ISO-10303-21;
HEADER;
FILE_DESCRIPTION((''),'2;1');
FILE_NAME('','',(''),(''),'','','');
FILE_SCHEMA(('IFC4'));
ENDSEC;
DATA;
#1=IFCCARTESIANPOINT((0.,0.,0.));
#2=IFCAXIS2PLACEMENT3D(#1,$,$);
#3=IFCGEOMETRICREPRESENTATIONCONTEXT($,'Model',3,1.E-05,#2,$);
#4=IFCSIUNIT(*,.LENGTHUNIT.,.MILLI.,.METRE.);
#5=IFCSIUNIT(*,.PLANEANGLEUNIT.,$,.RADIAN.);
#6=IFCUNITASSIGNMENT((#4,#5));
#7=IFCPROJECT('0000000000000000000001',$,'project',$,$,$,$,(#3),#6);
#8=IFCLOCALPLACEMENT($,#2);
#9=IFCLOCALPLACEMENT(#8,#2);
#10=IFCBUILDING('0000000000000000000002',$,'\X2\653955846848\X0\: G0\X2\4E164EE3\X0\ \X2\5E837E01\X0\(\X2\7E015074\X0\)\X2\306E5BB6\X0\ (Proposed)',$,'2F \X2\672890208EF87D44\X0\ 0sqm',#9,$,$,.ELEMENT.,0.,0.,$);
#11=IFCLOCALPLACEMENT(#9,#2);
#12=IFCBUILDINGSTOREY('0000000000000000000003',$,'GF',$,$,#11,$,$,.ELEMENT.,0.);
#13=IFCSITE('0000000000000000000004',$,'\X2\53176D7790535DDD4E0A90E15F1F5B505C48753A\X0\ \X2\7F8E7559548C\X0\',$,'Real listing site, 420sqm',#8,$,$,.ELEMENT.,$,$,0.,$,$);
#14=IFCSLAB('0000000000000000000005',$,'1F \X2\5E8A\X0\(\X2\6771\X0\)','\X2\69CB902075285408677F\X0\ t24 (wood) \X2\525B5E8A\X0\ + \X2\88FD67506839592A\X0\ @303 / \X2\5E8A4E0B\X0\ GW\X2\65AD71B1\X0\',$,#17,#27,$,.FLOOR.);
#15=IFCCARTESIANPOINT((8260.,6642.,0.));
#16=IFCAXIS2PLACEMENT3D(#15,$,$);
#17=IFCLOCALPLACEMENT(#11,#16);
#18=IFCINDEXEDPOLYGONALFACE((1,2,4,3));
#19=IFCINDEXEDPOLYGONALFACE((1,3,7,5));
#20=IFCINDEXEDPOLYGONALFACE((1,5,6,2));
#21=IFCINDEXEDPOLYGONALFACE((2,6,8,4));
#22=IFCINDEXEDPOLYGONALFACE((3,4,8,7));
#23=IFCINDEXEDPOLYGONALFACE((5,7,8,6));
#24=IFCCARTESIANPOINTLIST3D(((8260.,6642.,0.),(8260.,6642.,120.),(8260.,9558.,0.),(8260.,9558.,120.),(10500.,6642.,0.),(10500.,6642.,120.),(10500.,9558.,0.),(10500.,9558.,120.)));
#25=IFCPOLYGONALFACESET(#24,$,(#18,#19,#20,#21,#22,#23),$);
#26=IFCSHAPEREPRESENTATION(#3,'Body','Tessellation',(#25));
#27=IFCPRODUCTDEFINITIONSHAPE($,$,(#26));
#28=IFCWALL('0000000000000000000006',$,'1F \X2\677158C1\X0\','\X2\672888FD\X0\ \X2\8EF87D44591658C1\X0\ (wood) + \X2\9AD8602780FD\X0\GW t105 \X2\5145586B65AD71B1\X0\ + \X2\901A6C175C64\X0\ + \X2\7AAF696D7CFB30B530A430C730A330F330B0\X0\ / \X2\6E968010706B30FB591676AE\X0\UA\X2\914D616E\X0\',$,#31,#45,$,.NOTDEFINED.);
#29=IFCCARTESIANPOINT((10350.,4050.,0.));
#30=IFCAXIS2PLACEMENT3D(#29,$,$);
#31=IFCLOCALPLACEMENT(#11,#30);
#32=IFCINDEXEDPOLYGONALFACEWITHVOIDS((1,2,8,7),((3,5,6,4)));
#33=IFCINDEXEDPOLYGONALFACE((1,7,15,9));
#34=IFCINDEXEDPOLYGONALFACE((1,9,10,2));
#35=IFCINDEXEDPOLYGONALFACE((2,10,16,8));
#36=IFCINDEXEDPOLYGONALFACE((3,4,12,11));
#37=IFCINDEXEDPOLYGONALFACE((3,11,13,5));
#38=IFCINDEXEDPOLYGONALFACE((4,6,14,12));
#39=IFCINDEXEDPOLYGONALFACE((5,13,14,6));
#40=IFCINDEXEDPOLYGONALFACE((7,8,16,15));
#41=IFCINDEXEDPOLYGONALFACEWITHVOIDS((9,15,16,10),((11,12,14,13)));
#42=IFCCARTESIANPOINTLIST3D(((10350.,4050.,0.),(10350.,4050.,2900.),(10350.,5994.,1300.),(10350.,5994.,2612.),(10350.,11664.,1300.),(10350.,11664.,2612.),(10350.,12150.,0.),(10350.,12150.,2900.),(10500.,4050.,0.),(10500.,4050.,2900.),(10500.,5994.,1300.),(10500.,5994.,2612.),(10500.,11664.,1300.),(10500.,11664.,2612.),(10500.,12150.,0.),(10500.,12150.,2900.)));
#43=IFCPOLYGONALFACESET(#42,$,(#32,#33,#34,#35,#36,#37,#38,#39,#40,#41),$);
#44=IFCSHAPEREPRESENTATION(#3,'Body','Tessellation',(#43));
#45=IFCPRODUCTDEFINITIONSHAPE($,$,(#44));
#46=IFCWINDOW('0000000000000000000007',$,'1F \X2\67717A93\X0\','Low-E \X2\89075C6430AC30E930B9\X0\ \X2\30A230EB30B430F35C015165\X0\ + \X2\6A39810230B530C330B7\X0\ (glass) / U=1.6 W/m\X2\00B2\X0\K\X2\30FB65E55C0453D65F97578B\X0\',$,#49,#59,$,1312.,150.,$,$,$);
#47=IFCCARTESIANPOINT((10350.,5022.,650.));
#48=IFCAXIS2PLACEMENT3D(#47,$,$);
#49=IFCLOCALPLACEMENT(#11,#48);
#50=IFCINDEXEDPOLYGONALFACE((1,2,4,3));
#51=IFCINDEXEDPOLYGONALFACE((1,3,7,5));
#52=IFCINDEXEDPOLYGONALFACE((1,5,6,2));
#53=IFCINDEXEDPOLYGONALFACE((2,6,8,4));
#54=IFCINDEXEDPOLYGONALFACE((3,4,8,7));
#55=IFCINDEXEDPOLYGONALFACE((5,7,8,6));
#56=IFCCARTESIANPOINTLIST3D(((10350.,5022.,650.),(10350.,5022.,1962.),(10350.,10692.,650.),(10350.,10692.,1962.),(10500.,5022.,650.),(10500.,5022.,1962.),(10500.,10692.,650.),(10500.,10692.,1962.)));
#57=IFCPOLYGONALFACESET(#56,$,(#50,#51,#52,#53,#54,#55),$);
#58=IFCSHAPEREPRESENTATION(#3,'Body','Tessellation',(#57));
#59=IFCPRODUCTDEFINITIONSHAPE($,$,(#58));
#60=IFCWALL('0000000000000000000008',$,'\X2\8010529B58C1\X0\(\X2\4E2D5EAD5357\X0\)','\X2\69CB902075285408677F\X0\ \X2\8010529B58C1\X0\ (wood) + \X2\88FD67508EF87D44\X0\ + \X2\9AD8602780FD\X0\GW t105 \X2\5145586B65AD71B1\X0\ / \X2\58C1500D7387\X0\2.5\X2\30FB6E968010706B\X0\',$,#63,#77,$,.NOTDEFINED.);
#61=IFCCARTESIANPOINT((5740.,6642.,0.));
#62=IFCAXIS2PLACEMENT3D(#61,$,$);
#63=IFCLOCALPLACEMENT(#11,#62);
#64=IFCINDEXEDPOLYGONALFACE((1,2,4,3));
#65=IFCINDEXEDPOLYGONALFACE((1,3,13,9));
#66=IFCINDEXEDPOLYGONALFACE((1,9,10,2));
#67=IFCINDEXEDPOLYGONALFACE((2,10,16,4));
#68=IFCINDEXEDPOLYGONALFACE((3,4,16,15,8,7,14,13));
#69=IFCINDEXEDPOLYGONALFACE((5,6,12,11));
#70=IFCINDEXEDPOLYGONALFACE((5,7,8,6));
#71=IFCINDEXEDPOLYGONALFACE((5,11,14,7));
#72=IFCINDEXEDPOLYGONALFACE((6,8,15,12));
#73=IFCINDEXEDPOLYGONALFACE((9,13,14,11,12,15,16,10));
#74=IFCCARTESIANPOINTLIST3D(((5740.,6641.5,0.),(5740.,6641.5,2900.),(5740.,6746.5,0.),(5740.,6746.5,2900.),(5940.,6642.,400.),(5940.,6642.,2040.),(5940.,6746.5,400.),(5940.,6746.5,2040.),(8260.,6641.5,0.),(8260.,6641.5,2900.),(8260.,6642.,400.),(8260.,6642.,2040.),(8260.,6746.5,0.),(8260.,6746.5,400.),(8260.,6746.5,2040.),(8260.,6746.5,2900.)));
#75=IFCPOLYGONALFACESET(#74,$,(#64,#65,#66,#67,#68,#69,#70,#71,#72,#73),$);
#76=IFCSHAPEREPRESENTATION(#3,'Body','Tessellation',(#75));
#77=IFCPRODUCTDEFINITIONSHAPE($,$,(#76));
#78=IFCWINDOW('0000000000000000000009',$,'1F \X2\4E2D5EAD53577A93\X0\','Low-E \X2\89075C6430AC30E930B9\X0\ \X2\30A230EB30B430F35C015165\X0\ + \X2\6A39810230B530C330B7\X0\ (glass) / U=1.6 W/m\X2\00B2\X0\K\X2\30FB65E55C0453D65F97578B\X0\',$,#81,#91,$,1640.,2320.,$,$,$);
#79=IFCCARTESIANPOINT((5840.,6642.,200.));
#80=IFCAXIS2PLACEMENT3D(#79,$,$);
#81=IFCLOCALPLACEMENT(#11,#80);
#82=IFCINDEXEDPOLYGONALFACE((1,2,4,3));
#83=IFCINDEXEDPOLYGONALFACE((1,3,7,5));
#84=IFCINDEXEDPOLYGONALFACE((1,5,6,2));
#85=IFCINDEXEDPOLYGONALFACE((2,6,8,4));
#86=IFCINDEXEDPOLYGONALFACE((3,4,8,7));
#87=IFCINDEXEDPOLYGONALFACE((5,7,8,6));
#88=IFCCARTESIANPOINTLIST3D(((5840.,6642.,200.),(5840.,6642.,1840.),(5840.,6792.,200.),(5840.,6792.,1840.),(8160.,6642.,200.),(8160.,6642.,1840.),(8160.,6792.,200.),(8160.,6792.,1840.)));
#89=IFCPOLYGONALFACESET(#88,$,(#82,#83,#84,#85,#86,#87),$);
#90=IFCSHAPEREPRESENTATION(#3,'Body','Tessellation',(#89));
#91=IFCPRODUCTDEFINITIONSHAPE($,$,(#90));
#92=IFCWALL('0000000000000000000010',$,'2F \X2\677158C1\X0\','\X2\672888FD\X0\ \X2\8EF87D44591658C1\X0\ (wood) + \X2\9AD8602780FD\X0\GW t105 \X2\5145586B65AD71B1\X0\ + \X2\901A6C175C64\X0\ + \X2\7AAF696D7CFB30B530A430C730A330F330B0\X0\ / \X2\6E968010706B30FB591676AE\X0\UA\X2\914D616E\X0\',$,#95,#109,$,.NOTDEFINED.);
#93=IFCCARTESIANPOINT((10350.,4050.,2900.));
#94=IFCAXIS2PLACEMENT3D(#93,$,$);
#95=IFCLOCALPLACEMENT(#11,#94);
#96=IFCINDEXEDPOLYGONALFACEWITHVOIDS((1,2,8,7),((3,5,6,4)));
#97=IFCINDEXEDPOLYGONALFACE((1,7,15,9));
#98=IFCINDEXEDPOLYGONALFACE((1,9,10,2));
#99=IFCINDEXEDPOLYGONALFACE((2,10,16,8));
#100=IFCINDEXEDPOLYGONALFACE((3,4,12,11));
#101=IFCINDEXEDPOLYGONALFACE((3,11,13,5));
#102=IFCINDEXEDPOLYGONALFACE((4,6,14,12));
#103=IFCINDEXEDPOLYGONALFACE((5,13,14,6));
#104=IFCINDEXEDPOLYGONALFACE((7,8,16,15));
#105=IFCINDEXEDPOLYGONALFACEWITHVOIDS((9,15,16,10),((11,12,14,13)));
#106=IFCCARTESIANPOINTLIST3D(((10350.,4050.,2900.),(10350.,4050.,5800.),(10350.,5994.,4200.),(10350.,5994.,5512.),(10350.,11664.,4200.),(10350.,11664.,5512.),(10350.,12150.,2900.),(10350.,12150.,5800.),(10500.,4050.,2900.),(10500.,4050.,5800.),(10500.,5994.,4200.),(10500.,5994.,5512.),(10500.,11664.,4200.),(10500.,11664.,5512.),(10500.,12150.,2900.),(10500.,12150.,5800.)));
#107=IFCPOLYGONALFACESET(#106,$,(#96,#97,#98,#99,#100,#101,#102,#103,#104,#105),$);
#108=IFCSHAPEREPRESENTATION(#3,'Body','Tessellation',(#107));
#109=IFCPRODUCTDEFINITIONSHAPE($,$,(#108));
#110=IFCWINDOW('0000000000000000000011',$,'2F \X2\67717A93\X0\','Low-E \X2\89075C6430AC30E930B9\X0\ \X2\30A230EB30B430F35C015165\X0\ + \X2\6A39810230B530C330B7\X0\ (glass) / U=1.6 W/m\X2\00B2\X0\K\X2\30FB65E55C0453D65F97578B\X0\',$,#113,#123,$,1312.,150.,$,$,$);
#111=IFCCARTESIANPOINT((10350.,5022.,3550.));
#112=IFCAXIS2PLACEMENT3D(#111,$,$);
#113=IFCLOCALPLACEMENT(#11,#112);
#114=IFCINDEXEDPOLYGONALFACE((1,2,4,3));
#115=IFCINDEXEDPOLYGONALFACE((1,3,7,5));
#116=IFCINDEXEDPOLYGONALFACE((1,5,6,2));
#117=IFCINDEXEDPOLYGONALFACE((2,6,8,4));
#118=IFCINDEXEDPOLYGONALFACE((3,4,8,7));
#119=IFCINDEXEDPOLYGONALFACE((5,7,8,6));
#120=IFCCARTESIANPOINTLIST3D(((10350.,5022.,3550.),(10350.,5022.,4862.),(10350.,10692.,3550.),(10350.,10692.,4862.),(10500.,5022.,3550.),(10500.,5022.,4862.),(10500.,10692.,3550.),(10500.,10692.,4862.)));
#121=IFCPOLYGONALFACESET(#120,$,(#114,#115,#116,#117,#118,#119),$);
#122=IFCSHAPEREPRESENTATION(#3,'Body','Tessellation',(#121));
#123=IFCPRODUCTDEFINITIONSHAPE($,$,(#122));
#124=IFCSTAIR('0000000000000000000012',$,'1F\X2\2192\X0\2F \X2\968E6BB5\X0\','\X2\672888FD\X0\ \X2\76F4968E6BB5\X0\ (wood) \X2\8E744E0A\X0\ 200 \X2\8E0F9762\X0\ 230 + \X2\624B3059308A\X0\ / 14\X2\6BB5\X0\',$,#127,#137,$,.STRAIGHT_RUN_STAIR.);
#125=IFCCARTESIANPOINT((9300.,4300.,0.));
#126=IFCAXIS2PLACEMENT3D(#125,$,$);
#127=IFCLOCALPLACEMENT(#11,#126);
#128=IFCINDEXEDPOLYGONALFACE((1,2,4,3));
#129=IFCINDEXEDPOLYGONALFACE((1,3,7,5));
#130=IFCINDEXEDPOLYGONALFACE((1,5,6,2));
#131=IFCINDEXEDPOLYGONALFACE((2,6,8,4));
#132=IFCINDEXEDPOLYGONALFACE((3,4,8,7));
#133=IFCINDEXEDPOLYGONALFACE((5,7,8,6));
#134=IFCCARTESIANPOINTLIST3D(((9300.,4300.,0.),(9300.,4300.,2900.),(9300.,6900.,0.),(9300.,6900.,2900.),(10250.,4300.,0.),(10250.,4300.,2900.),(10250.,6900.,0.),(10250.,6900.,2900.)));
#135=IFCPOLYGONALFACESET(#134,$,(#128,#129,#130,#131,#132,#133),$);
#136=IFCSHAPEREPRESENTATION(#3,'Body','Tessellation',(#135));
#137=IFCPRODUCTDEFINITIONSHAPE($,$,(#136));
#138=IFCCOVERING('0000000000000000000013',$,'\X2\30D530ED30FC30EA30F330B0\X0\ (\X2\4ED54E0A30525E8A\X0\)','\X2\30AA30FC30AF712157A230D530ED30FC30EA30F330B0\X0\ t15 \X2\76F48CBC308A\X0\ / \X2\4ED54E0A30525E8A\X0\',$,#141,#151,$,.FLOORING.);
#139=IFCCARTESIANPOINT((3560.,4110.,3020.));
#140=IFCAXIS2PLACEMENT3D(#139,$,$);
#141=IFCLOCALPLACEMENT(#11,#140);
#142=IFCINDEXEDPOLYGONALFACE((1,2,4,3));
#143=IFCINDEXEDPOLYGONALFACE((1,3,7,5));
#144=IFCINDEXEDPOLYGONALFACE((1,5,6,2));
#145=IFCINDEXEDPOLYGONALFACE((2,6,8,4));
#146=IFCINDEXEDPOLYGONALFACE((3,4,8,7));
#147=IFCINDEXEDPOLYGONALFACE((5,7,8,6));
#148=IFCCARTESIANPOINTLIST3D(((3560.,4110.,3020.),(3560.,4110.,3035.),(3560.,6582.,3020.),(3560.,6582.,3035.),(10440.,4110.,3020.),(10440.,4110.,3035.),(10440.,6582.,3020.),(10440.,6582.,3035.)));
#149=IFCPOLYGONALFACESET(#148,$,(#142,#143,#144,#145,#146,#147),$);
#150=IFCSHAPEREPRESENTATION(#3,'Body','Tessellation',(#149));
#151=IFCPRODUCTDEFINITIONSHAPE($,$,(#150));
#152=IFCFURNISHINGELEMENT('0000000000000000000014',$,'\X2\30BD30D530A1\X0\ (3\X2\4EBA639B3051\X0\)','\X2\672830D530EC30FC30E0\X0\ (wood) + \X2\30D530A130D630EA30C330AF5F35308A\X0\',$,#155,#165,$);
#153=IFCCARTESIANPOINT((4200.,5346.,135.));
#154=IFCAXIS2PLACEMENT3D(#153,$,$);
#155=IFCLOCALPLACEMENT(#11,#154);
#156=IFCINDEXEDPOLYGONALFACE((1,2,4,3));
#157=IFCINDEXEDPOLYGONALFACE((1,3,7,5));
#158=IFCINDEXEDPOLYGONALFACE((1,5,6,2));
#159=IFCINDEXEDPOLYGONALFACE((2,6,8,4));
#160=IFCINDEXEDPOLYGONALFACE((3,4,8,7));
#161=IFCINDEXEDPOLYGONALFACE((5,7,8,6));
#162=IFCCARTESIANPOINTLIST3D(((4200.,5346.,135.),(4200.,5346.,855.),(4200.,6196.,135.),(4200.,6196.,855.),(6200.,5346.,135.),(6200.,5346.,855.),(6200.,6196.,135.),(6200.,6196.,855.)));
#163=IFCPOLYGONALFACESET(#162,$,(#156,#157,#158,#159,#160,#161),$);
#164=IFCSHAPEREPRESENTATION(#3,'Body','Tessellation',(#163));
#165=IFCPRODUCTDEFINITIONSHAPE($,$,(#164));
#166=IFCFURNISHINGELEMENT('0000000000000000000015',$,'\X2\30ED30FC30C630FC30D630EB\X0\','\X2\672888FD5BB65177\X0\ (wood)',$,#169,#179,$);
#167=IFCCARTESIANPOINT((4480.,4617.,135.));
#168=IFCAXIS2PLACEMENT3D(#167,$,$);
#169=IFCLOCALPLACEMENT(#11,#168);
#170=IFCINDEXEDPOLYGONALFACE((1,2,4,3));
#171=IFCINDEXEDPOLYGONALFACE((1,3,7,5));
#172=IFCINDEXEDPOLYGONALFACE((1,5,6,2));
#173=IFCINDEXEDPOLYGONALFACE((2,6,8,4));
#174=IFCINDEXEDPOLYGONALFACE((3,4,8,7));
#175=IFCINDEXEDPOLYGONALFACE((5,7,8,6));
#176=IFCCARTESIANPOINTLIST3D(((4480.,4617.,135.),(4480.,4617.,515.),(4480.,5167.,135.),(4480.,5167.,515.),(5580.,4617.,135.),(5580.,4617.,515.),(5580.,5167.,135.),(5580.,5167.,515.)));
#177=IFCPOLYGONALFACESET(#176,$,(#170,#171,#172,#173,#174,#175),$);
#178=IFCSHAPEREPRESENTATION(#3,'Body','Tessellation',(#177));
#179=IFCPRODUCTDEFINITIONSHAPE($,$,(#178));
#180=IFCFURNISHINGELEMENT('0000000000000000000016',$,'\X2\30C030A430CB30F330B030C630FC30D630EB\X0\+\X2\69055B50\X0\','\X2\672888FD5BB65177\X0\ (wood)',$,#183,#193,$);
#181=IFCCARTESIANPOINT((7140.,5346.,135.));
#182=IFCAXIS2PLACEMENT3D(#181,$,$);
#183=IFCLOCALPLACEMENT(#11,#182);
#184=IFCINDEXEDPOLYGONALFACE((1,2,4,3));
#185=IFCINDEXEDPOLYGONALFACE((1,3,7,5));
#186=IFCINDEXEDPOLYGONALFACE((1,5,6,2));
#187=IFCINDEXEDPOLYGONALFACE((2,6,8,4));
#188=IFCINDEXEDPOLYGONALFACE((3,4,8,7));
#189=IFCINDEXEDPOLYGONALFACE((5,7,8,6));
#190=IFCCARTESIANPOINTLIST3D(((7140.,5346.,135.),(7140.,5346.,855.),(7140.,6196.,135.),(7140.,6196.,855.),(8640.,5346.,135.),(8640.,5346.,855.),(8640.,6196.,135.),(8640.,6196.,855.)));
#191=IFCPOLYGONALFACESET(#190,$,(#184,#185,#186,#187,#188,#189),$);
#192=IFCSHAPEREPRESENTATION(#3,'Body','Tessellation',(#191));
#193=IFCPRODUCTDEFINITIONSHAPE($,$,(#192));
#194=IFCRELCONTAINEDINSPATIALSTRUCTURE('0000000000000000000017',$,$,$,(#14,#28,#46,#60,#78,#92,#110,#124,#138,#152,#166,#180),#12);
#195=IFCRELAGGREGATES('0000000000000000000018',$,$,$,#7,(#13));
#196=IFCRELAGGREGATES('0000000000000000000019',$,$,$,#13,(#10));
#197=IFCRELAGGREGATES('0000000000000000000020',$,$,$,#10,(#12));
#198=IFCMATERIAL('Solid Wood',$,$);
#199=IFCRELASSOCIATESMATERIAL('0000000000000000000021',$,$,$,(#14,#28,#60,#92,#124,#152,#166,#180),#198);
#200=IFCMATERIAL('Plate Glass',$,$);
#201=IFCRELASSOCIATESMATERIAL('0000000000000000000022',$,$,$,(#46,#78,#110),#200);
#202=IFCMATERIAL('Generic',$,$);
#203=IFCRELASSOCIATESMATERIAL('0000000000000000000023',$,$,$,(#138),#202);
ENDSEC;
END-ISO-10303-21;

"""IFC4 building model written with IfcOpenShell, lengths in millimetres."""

from ifc_helpers import new_model, si_unit, frame, frame_2d, origin, place, context, project, spatial, rectangle, extrude, material, element, fill, save


model = new_model("IFC4")

# Units and contexts
model_context = context("Model", 3, precision=1e-05, world=origin())
ifc_project = project(units=[si_unit("LENGTHUNIT", "METRE", prefix="MILLI"), si_unit("PLANEANGLEUNIT", "RADIAN")], contexts=[model_context])

# Site, building, storey
site_placement = place(None, origin())
site = spatial("IfcSite", under=ifc_project, at=site_placement, Name="北海道川上郡弟子屈町 美留和", ObjectType="Real listing site, 420sqm", CompositionType="ELEMENT", RefElevation=0.0)
building_placement = place(site_placement, origin())
building = spatial("IfcBuilding", under=site, at=building_placement, Name="改善案: G0世代 広縁(縁側)の家 (Proposed)", ObjectType="2F 木造軸組 0sqm", CompositionType="ELEMENT", ElevationOfRefHeight=0.0, ElevationOfTerrain=0.0)
storey_placement = place(building_placement, origin())
storey = spatial("IfcBuildingStorey", under=building, at=storey_placement, Name="GF", CompositionType="ELEMENT", Elevation=0.0)

# Slab
ifc_material_1 = material(Name="Solid Wood")
slab_placement = place(storey_placement, frame((8260.0, 6642.0, 0.0)))
element("IfcSlab", 1, at=slab_placement, inside=storey, material=ifc_material_1, Name="1F 床(東)", Description="構造用合板 t24 (wood) 剛床 + 製材根太 @303 / 床下 GW断熱", PredefinedType="FLOOR", context=model_context, shape_type="SweptSolid", body=[
    extrude(rectangle(XDim=2240.0, YDim=2916.0, at=frame_2d((1120.0, 1458.0))), frame((8260.0, 6642.0, 0.0)), (0.0, 0.0, 1.0), 120.0),
])

# Walls, openings, windows
wall_1_placement = place(storey_placement, frame((10350.0, 4050.0, 0.0)))
wall_1 = element("IfcWall", 2, at=wall_1_placement, inside=storey, material=ifc_material_1, Name="1F 東壁", Description="木製 軸組外壁 (wood) + 高性能GW t105 充填断熱 + 通気層 + 窯業系サイディング / 準耐火・外皮UA配慮", PredefinedType="NOTDEFINED", context=model_context, shape_type="SweptSolid", body=[
    extrude(rectangle(XDim=150.0, YDim=8100.0, at=frame_2d((75.0, 4050.0))), frame((10350.0, 4050.0, 0.0)), (0.0, 0.0, 1.0), 2900.0),
])
opening_1_placement = place(storey_placement, frame((10350.0, 5022.0, 650.0)))
opening_1 = element("IfcOpeningElement", 3, at=opening_1_placement, cuts=wall_1, PredefinedType="NOTDEFINED", context=model_context, shape_type="SweptSolid", body=[
    extrude(rectangle(XDim=150.0, YDim=5670.0, at=frame_2d((75.0, 2835.0))), frame((10350.0, 5022.0, 650.0)), (0.0, 0.0, 1.0), 1312.0),
])
ifc_material_2 = material(Name="Plate Glass")
window_1_placement = place(storey_placement, frame((10350.0, 5022.0, 650.0)))
window_1 = element("IfcWindow", 4, at=window_1_placement, inside=storey, material=ifc_material_2, Name="1F 東窓", Description="Low-E 複層ガラス アルゴン封入 + 樹脂サッシ (glass) / U=1.6 W/m²K・日射取得型", OverallHeight=1312.0, OverallWidth=150.0, context=model_context, shape_type="SweptSolid", body=[
    extrude(rectangle(XDim=150.0, YDim=5670.0, at=frame_2d((75.0, 2835.0))), frame((10350.0, 5022.0, 650.0)), (0.0, 0.0, 1.0), 1312.0),
])
fill(opening_1, window_1)
wall_2_placement = place(storey_placement, frame((5740.0, 6642.0, 0.0)))
wall_2 = element("IfcWall", 5, at=wall_2_placement, inside=storey, material=ifc_material_1, Name="耐力壁(中庭南)", Description="構造用合板 耐力壁 (wood) + 製材軸組 + 高性能GW t105 充填断熱 / 壁倍率2.5・準耐火", PredefinedType="NOTDEFINED", context=model_context, shape_type="SweptSolid", body=[
    extrude(rectangle(XDim=2520.0, YDim=105.0, at=frame_2d((1260.0, 52.0))), frame((5740.0, 6642.0, 0.0)), (0.0, 0.0, 1.0), 2900.0),
])
opening_2_placement = place(storey_placement, frame((5840.0, 6642.0, 200.0)))
opening_2 = element("IfcOpeningElement", 6, at=opening_2_placement, cuts=wall_2, PredefinedType="NOTDEFINED", context=model_context, shape_type="SweptSolid", body=[
    extrude(rectangle(XDim=2320.0, YDim=150.0, at=frame_2d((1160.0, 75.0))), frame((5840.0, 6642.0, 200.0)), (0.0, 0.0, 1.0), 1640.0),
])
window_2_placement = place(storey_placement, frame((5840.0, 6642.0, 200.0)))
window_2 = element("IfcWindow", 7, at=window_2_placement, inside=storey, material=ifc_material_2, Name="1F 中庭南窓", Description="Low-E 複層ガラス アルゴン封入 + 樹脂サッシ (glass) / U=1.6 W/m²K・日射取得型", OverallHeight=1640.0, OverallWidth=2320.0, context=model_context, shape_type="SweptSolid", body=[
    extrude(rectangle(XDim=2320.0, YDim=150.0, at=frame_2d((1160.0, 75.0))), frame((5840.0, 6642.0, 200.0)), (0.0, 0.0, 1.0), 1640.0),
])
fill(opening_2, window_2)

# Wall, opening, window
wall_3_placement = place(storey_placement, frame((10350.0, 4050.0, 2900.0)))
wall_3 = element("IfcWall", 8, at=wall_3_placement, inside=storey, material=ifc_material_1, Name="2F 東壁", Description="木製 軸組外壁 (wood) + 高性能GW t105 充填断熱 + 通気層 + 窯業系サイディング / 準耐火・外皮UA配慮", PredefinedType="NOTDEFINED", context=model_context, shape_type="SweptSolid", body=[
    extrude(rectangle(XDim=150.0, YDim=8100.0, at=frame_2d((75.0, 4050.0))), frame((10350.0, 4050.0, 2900.0)), (0.0, 0.0, 1.0), 2900.0),
])
opening_3_placement = place(storey_placement, frame((10350.0, 5022.0, 3550.0)))
opening_3 = element("IfcOpeningElement", 9, at=opening_3_placement, cuts=wall_3, PredefinedType="NOTDEFINED", context=model_context, shape_type="SweptSolid", body=[
    extrude(rectangle(XDim=150.0, YDim=5670.0, at=frame_2d((75.0, 2835.0))), frame((10350.0, 5022.0, 3550.0)), (0.0, 0.0, 1.0), 1312.0),
])
window_3_placement = place(storey_placement, frame((10350.0, 5022.0, 3550.0)))
window_3 = element("IfcWindow", 10, at=window_3_placement, inside=storey, material=ifc_material_2, Name="2F 東窓", Description="Low-E 複層ガラス アルゴン封入 + 樹脂サッシ (glass) / U=1.6 W/m²K・日射取得型", OverallHeight=1312.0, OverallWidth=150.0, context=model_context, shape_type="SweptSolid", body=[
    extrude(rectangle(XDim=150.0, YDim=5670.0, at=frame_2d((75.0, 2835.0))), frame((10350.0, 5022.0, 3550.0)), (0.0, 0.0, 1.0), 1312.0),
])
fill(opening_3, window_3)

# Stair
stair_placement = place(storey_placement, frame((9300.0, 4300.0, 0.0)))
element("IfcStair", 11, at=stair_placement, inside=storey, material=ifc_material_1, Name="1F→2F 階段", Description="木製 直階段 (wood) 蹴上 200 踏面 230 + 手すり / 14段", PredefinedType="STRAIGHT_RUN_STAIR", context=model_context, shape_type="SweptSolid", body=[
    extrude(rectangle(XDim=950.0, YDim=2600.0, at=frame_2d((475.0, 1300.0))), frame((9300.0, 4300.0, 0.0)), (0.0, 0.0, 1.0), 2900.0),
])

# Covering
ifc_material_3 = material(Name="Generic")
covering_placement = place(storey_placement, frame((3560.0, 4110.0, 3020.0)))
element("IfcCovering", 12, at=covering_placement, inside=storey, material=ifc_material_3, Name="フローリング (仕上げ床)", Description="オーク無垢フローリング t15 直貼り / 仕上げ床", PredefinedType="FLOORING", context=model_context, shape_type="SweptSolid", body=[
    extrude(rectangle(XDim=6880.0, YDim=2472.0, at=frame_2d((3440.0, 1236.0))), frame((3560.0, 4110.0, 3020.0)), (0.0, 0.0, 1.0), 15.0),
])

# Furnishing elements
furnishing_1_placement = place(storey_placement, frame((4200.0, 5346.0, 135.0)))
element("IfcFurnishingElement", 13, at=furnishing_1_placement, inside=storey, material=ifc_material_1, Name="ソファ (3人掛け)", Description="木フレーム (wood) + ファブリック張り", context=model_context, shape_type="SweptSolid", body=[
    extrude(rectangle(XDim=2000.0, YDim=850.0, at=frame_2d((1000.0, 425.0))), frame((4200.0, 5346.0, 135.0)), (0.0, 0.0, 1.0), 720.0),
])
furnishing_2_placement = place(storey_placement, frame((4480.0, 4617.0, 135.0)))
element("IfcFurnishingElement", 14, at=furnishing_2_placement, inside=storey, material=ifc_material_1, Name="ローテーブル", Description="木製家具 (wood)", context=model_context, shape_type="SweptSolid", body=[
    extrude(rectangle(XDim=1100.0, YDim=550.0, at=frame_2d((550.0, 275.0))), frame((4480.0, 4617.0, 135.0)), (0.0, 0.0, 1.0), 380.0),
])
furnishing_3_placement = place(storey_placement, frame((7140.0, 5346.0, 135.0)))
element("IfcFurnishingElement", 15, at=furnishing_3_placement, inside=storey, material=ifc_material_1, Name="ダイニングテーブル+椅子", Description="木製家具 (wood)", context=model_context, shape_type="SweptSolid", body=[
    extrude(rectangle(XDim=1500.0, YDim=850.0, at=frame_2d((750.0, 425.0))), frame((7140.0, 5346.0, 135.0)), (0.0, 0.0, 1.0), 720.0),
])

save(model, "model.ifc")
